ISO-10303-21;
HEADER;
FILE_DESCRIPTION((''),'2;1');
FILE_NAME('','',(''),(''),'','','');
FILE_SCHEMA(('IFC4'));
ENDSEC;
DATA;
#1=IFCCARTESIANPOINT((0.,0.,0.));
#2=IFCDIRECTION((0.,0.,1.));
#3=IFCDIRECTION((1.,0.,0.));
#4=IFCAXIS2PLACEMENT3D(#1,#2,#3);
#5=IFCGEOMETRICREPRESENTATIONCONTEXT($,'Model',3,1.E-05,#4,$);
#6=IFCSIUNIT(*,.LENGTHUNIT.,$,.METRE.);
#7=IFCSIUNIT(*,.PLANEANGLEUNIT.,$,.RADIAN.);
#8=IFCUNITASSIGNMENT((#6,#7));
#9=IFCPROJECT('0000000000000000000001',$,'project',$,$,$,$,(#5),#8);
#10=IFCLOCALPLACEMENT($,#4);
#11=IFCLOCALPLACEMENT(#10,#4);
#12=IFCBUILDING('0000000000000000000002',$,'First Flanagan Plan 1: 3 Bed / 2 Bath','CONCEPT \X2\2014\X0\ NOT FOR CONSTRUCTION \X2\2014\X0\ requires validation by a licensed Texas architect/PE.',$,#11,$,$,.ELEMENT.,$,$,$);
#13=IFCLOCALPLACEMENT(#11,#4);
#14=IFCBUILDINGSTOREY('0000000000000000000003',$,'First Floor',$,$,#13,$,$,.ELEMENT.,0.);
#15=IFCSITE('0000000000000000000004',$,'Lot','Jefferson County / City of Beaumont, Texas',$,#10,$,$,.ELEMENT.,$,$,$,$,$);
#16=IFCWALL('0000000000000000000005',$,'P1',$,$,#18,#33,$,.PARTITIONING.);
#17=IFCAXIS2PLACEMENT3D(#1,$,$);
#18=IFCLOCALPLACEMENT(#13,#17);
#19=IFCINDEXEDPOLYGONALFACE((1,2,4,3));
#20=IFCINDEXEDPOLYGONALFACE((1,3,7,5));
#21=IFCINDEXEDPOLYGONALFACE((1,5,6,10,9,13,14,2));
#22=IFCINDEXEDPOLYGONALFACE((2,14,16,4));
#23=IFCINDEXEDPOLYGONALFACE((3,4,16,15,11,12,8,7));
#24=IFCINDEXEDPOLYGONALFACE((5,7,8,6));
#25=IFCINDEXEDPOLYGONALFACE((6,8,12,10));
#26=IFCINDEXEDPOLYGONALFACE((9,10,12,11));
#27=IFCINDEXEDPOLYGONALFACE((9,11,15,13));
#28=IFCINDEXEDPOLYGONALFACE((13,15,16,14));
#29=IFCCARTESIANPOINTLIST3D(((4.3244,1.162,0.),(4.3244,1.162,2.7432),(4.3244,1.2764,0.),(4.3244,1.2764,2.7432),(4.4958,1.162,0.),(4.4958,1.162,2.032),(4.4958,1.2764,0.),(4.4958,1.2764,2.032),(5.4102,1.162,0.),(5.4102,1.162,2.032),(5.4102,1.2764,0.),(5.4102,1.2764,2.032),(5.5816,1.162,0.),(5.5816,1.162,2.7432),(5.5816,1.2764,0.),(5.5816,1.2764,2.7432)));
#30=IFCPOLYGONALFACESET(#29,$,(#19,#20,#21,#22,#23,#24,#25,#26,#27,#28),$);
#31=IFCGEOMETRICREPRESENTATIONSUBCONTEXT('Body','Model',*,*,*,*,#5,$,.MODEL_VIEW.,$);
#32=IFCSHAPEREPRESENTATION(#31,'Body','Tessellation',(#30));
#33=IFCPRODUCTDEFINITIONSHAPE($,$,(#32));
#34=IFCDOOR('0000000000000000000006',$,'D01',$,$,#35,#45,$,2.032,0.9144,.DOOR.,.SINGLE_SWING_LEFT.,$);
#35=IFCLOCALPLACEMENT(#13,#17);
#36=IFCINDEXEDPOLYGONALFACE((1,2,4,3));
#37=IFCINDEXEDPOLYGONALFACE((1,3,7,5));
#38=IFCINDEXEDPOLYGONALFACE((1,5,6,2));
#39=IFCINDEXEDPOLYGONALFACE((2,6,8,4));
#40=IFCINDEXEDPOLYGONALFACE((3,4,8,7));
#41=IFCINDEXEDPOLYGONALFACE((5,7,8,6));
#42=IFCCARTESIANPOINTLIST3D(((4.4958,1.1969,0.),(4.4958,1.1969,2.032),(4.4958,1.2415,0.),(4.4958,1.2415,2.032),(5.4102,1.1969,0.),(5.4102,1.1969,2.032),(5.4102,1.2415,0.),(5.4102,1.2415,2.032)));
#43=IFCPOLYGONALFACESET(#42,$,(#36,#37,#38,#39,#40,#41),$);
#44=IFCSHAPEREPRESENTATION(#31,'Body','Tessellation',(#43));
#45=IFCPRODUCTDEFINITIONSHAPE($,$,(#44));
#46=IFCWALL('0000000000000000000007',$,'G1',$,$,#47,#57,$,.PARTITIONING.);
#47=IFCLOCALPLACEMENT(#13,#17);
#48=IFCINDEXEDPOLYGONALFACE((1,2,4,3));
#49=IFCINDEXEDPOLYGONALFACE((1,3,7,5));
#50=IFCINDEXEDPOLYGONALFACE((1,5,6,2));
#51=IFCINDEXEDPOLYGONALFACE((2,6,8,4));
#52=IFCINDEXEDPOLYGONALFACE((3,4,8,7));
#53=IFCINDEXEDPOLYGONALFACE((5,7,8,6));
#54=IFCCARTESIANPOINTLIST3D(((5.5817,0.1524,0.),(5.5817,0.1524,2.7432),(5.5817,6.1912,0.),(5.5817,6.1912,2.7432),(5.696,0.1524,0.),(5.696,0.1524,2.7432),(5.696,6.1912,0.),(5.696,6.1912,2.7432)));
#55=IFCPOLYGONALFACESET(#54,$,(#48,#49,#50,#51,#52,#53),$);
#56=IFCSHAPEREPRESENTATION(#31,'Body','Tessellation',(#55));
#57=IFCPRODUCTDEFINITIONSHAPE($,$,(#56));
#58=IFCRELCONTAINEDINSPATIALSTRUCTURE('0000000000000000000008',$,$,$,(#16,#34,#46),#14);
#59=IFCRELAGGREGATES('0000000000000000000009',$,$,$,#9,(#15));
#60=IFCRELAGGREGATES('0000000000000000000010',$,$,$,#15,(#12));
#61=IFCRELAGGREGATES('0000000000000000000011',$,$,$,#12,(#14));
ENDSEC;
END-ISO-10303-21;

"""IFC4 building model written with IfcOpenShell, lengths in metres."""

from ifc_helpers import new_model, si_unit, frame, frame_2d, origin_with_axes, place, context, subcontext, project, spatial, rectangle, extrude, element, fill, save


model = new_model("IFC4")

# Units and contexts
model_context = context("Model", 3, precision=1e-05, world=origin_with_axes())
body_context = subcontext(model_context, "Body", "Model", "MODEL_VIEW")
ifc_project = project(units=[si_unit("LENGTHUNIT", "METRE"), si_unit("PLANEANGLEUNIT", "RADIAN")], contexts=[model_context])

# Site, building, storey
site_placement = place(None, origin_with_axes())
site = spatial("IfcSite", under=ifc_project, at=site_placement, Name="Lot", Description="Jefferson County / City of Beaumont, Texas", CompositionType="ELEMENT")
building_placement = place(site_placement, origin_with_axes())
building = spatial("IfcBuilding", under=site, at=building_placement, Name="First Flanagan Plan 1: 3 Bed / 2 Bath", Description="CONCEPT — NOT FOR CONSTRUCTION — requires validation by a licensed Texas architect/PE.", CompositionType="ELEMENT")
storey_placement = place(building_placement, origin_with_axes())
storey = spatial("IfcBuildingStorey", under=building, at=storey_placement, Name="First Floor", CompositionType="ELEMENT", Elevation=0.0)

# Wall, opening, door
wall_1_placement = place(storey_placement, frame((4.3243, 1.2192, 0.0), z_axis=(0.0, 0.0, 1.0), x_axis=(1.0, 0.0, 0.0)))
wall_1 = element("IfcWall", 1, at=wall_1_placement, inside=storey, Name="P1", PredefinedType="PARTITIONING", context=body_context, shape_type="SweptSolid", body=[
    extrude(rectangle(XDim=1.2573, YDim=0.1143, at=frame_2d((0.6287, 0.0), x_axis=(1.0, 0.0))), origin_with_axes(), (0.0, 0.0, 1.0), 2.7432),
])
opening_1_placement = place(wall_1_placement, frame((0.1715, 0.0, 0.0), z_axis=(0.0, 0.0, 1.0), x_axis=(1.0, 0.0, 0.0)))
opening_1 = element("IfcOpeningElement", 2, at=opening_1_placement, cuts=wall_1, PredefinedType="OPENING", context=body_context, shape_type="SweptSolid", body=[
    extrude(rectangle(XDim=0.9144, YDim=0.1448, at=frame_2d((0.4572, 0.0), x_axis=(1.0, 0.0))), origin_with_axes(), (0.0, 0.0, 1.0), 2.032),
])
door_1_placement = place(opening_1_placement, origin_with_axes())
door_1 = element("IfcDoor", 3, at=door_1_placement, inside=storey, Name="D01", OperationType="SINGLE_SWING_LEFT", OverallHeight=2.032, OverallWidth=0.9144, PredefinedType="DOOR", context=body_context, shape_type="SweptSolid", body=[
    extrude(rectangle(XDim=0.9144, YDim=0.0445, at=frame_2d((0.4572, 0.0), x_axis=(1.0, 0.0))), origin_with_axes(), (0.0, 0.0, 1.0), 2.032),
])
fill(opening_1, door_1)

# Wall
wall_2_placement = place(storey_placement, frame((5.6388, 0.1524, 0.0), z_axis=(0.0, 0.0, 1.0), x_axis=(0.0, 1.0, 0.0)))
element("IfcWall", 4, at=wall_2_placement, inside=storey, Name="G1", PredefinedType="PARTITIONING", context=body_context, shape_type="SweptSolid", body=[
    extrude(rectangle(XDim=6.0389, YDim=0.1143, at=frame_2d((3.0194, 0.0), x_axis=(1.0, 0.0))), origin_with_axes(), (0.0, 0.0, 1.0), 2.7432),
])

save(model, "model.ifc")
